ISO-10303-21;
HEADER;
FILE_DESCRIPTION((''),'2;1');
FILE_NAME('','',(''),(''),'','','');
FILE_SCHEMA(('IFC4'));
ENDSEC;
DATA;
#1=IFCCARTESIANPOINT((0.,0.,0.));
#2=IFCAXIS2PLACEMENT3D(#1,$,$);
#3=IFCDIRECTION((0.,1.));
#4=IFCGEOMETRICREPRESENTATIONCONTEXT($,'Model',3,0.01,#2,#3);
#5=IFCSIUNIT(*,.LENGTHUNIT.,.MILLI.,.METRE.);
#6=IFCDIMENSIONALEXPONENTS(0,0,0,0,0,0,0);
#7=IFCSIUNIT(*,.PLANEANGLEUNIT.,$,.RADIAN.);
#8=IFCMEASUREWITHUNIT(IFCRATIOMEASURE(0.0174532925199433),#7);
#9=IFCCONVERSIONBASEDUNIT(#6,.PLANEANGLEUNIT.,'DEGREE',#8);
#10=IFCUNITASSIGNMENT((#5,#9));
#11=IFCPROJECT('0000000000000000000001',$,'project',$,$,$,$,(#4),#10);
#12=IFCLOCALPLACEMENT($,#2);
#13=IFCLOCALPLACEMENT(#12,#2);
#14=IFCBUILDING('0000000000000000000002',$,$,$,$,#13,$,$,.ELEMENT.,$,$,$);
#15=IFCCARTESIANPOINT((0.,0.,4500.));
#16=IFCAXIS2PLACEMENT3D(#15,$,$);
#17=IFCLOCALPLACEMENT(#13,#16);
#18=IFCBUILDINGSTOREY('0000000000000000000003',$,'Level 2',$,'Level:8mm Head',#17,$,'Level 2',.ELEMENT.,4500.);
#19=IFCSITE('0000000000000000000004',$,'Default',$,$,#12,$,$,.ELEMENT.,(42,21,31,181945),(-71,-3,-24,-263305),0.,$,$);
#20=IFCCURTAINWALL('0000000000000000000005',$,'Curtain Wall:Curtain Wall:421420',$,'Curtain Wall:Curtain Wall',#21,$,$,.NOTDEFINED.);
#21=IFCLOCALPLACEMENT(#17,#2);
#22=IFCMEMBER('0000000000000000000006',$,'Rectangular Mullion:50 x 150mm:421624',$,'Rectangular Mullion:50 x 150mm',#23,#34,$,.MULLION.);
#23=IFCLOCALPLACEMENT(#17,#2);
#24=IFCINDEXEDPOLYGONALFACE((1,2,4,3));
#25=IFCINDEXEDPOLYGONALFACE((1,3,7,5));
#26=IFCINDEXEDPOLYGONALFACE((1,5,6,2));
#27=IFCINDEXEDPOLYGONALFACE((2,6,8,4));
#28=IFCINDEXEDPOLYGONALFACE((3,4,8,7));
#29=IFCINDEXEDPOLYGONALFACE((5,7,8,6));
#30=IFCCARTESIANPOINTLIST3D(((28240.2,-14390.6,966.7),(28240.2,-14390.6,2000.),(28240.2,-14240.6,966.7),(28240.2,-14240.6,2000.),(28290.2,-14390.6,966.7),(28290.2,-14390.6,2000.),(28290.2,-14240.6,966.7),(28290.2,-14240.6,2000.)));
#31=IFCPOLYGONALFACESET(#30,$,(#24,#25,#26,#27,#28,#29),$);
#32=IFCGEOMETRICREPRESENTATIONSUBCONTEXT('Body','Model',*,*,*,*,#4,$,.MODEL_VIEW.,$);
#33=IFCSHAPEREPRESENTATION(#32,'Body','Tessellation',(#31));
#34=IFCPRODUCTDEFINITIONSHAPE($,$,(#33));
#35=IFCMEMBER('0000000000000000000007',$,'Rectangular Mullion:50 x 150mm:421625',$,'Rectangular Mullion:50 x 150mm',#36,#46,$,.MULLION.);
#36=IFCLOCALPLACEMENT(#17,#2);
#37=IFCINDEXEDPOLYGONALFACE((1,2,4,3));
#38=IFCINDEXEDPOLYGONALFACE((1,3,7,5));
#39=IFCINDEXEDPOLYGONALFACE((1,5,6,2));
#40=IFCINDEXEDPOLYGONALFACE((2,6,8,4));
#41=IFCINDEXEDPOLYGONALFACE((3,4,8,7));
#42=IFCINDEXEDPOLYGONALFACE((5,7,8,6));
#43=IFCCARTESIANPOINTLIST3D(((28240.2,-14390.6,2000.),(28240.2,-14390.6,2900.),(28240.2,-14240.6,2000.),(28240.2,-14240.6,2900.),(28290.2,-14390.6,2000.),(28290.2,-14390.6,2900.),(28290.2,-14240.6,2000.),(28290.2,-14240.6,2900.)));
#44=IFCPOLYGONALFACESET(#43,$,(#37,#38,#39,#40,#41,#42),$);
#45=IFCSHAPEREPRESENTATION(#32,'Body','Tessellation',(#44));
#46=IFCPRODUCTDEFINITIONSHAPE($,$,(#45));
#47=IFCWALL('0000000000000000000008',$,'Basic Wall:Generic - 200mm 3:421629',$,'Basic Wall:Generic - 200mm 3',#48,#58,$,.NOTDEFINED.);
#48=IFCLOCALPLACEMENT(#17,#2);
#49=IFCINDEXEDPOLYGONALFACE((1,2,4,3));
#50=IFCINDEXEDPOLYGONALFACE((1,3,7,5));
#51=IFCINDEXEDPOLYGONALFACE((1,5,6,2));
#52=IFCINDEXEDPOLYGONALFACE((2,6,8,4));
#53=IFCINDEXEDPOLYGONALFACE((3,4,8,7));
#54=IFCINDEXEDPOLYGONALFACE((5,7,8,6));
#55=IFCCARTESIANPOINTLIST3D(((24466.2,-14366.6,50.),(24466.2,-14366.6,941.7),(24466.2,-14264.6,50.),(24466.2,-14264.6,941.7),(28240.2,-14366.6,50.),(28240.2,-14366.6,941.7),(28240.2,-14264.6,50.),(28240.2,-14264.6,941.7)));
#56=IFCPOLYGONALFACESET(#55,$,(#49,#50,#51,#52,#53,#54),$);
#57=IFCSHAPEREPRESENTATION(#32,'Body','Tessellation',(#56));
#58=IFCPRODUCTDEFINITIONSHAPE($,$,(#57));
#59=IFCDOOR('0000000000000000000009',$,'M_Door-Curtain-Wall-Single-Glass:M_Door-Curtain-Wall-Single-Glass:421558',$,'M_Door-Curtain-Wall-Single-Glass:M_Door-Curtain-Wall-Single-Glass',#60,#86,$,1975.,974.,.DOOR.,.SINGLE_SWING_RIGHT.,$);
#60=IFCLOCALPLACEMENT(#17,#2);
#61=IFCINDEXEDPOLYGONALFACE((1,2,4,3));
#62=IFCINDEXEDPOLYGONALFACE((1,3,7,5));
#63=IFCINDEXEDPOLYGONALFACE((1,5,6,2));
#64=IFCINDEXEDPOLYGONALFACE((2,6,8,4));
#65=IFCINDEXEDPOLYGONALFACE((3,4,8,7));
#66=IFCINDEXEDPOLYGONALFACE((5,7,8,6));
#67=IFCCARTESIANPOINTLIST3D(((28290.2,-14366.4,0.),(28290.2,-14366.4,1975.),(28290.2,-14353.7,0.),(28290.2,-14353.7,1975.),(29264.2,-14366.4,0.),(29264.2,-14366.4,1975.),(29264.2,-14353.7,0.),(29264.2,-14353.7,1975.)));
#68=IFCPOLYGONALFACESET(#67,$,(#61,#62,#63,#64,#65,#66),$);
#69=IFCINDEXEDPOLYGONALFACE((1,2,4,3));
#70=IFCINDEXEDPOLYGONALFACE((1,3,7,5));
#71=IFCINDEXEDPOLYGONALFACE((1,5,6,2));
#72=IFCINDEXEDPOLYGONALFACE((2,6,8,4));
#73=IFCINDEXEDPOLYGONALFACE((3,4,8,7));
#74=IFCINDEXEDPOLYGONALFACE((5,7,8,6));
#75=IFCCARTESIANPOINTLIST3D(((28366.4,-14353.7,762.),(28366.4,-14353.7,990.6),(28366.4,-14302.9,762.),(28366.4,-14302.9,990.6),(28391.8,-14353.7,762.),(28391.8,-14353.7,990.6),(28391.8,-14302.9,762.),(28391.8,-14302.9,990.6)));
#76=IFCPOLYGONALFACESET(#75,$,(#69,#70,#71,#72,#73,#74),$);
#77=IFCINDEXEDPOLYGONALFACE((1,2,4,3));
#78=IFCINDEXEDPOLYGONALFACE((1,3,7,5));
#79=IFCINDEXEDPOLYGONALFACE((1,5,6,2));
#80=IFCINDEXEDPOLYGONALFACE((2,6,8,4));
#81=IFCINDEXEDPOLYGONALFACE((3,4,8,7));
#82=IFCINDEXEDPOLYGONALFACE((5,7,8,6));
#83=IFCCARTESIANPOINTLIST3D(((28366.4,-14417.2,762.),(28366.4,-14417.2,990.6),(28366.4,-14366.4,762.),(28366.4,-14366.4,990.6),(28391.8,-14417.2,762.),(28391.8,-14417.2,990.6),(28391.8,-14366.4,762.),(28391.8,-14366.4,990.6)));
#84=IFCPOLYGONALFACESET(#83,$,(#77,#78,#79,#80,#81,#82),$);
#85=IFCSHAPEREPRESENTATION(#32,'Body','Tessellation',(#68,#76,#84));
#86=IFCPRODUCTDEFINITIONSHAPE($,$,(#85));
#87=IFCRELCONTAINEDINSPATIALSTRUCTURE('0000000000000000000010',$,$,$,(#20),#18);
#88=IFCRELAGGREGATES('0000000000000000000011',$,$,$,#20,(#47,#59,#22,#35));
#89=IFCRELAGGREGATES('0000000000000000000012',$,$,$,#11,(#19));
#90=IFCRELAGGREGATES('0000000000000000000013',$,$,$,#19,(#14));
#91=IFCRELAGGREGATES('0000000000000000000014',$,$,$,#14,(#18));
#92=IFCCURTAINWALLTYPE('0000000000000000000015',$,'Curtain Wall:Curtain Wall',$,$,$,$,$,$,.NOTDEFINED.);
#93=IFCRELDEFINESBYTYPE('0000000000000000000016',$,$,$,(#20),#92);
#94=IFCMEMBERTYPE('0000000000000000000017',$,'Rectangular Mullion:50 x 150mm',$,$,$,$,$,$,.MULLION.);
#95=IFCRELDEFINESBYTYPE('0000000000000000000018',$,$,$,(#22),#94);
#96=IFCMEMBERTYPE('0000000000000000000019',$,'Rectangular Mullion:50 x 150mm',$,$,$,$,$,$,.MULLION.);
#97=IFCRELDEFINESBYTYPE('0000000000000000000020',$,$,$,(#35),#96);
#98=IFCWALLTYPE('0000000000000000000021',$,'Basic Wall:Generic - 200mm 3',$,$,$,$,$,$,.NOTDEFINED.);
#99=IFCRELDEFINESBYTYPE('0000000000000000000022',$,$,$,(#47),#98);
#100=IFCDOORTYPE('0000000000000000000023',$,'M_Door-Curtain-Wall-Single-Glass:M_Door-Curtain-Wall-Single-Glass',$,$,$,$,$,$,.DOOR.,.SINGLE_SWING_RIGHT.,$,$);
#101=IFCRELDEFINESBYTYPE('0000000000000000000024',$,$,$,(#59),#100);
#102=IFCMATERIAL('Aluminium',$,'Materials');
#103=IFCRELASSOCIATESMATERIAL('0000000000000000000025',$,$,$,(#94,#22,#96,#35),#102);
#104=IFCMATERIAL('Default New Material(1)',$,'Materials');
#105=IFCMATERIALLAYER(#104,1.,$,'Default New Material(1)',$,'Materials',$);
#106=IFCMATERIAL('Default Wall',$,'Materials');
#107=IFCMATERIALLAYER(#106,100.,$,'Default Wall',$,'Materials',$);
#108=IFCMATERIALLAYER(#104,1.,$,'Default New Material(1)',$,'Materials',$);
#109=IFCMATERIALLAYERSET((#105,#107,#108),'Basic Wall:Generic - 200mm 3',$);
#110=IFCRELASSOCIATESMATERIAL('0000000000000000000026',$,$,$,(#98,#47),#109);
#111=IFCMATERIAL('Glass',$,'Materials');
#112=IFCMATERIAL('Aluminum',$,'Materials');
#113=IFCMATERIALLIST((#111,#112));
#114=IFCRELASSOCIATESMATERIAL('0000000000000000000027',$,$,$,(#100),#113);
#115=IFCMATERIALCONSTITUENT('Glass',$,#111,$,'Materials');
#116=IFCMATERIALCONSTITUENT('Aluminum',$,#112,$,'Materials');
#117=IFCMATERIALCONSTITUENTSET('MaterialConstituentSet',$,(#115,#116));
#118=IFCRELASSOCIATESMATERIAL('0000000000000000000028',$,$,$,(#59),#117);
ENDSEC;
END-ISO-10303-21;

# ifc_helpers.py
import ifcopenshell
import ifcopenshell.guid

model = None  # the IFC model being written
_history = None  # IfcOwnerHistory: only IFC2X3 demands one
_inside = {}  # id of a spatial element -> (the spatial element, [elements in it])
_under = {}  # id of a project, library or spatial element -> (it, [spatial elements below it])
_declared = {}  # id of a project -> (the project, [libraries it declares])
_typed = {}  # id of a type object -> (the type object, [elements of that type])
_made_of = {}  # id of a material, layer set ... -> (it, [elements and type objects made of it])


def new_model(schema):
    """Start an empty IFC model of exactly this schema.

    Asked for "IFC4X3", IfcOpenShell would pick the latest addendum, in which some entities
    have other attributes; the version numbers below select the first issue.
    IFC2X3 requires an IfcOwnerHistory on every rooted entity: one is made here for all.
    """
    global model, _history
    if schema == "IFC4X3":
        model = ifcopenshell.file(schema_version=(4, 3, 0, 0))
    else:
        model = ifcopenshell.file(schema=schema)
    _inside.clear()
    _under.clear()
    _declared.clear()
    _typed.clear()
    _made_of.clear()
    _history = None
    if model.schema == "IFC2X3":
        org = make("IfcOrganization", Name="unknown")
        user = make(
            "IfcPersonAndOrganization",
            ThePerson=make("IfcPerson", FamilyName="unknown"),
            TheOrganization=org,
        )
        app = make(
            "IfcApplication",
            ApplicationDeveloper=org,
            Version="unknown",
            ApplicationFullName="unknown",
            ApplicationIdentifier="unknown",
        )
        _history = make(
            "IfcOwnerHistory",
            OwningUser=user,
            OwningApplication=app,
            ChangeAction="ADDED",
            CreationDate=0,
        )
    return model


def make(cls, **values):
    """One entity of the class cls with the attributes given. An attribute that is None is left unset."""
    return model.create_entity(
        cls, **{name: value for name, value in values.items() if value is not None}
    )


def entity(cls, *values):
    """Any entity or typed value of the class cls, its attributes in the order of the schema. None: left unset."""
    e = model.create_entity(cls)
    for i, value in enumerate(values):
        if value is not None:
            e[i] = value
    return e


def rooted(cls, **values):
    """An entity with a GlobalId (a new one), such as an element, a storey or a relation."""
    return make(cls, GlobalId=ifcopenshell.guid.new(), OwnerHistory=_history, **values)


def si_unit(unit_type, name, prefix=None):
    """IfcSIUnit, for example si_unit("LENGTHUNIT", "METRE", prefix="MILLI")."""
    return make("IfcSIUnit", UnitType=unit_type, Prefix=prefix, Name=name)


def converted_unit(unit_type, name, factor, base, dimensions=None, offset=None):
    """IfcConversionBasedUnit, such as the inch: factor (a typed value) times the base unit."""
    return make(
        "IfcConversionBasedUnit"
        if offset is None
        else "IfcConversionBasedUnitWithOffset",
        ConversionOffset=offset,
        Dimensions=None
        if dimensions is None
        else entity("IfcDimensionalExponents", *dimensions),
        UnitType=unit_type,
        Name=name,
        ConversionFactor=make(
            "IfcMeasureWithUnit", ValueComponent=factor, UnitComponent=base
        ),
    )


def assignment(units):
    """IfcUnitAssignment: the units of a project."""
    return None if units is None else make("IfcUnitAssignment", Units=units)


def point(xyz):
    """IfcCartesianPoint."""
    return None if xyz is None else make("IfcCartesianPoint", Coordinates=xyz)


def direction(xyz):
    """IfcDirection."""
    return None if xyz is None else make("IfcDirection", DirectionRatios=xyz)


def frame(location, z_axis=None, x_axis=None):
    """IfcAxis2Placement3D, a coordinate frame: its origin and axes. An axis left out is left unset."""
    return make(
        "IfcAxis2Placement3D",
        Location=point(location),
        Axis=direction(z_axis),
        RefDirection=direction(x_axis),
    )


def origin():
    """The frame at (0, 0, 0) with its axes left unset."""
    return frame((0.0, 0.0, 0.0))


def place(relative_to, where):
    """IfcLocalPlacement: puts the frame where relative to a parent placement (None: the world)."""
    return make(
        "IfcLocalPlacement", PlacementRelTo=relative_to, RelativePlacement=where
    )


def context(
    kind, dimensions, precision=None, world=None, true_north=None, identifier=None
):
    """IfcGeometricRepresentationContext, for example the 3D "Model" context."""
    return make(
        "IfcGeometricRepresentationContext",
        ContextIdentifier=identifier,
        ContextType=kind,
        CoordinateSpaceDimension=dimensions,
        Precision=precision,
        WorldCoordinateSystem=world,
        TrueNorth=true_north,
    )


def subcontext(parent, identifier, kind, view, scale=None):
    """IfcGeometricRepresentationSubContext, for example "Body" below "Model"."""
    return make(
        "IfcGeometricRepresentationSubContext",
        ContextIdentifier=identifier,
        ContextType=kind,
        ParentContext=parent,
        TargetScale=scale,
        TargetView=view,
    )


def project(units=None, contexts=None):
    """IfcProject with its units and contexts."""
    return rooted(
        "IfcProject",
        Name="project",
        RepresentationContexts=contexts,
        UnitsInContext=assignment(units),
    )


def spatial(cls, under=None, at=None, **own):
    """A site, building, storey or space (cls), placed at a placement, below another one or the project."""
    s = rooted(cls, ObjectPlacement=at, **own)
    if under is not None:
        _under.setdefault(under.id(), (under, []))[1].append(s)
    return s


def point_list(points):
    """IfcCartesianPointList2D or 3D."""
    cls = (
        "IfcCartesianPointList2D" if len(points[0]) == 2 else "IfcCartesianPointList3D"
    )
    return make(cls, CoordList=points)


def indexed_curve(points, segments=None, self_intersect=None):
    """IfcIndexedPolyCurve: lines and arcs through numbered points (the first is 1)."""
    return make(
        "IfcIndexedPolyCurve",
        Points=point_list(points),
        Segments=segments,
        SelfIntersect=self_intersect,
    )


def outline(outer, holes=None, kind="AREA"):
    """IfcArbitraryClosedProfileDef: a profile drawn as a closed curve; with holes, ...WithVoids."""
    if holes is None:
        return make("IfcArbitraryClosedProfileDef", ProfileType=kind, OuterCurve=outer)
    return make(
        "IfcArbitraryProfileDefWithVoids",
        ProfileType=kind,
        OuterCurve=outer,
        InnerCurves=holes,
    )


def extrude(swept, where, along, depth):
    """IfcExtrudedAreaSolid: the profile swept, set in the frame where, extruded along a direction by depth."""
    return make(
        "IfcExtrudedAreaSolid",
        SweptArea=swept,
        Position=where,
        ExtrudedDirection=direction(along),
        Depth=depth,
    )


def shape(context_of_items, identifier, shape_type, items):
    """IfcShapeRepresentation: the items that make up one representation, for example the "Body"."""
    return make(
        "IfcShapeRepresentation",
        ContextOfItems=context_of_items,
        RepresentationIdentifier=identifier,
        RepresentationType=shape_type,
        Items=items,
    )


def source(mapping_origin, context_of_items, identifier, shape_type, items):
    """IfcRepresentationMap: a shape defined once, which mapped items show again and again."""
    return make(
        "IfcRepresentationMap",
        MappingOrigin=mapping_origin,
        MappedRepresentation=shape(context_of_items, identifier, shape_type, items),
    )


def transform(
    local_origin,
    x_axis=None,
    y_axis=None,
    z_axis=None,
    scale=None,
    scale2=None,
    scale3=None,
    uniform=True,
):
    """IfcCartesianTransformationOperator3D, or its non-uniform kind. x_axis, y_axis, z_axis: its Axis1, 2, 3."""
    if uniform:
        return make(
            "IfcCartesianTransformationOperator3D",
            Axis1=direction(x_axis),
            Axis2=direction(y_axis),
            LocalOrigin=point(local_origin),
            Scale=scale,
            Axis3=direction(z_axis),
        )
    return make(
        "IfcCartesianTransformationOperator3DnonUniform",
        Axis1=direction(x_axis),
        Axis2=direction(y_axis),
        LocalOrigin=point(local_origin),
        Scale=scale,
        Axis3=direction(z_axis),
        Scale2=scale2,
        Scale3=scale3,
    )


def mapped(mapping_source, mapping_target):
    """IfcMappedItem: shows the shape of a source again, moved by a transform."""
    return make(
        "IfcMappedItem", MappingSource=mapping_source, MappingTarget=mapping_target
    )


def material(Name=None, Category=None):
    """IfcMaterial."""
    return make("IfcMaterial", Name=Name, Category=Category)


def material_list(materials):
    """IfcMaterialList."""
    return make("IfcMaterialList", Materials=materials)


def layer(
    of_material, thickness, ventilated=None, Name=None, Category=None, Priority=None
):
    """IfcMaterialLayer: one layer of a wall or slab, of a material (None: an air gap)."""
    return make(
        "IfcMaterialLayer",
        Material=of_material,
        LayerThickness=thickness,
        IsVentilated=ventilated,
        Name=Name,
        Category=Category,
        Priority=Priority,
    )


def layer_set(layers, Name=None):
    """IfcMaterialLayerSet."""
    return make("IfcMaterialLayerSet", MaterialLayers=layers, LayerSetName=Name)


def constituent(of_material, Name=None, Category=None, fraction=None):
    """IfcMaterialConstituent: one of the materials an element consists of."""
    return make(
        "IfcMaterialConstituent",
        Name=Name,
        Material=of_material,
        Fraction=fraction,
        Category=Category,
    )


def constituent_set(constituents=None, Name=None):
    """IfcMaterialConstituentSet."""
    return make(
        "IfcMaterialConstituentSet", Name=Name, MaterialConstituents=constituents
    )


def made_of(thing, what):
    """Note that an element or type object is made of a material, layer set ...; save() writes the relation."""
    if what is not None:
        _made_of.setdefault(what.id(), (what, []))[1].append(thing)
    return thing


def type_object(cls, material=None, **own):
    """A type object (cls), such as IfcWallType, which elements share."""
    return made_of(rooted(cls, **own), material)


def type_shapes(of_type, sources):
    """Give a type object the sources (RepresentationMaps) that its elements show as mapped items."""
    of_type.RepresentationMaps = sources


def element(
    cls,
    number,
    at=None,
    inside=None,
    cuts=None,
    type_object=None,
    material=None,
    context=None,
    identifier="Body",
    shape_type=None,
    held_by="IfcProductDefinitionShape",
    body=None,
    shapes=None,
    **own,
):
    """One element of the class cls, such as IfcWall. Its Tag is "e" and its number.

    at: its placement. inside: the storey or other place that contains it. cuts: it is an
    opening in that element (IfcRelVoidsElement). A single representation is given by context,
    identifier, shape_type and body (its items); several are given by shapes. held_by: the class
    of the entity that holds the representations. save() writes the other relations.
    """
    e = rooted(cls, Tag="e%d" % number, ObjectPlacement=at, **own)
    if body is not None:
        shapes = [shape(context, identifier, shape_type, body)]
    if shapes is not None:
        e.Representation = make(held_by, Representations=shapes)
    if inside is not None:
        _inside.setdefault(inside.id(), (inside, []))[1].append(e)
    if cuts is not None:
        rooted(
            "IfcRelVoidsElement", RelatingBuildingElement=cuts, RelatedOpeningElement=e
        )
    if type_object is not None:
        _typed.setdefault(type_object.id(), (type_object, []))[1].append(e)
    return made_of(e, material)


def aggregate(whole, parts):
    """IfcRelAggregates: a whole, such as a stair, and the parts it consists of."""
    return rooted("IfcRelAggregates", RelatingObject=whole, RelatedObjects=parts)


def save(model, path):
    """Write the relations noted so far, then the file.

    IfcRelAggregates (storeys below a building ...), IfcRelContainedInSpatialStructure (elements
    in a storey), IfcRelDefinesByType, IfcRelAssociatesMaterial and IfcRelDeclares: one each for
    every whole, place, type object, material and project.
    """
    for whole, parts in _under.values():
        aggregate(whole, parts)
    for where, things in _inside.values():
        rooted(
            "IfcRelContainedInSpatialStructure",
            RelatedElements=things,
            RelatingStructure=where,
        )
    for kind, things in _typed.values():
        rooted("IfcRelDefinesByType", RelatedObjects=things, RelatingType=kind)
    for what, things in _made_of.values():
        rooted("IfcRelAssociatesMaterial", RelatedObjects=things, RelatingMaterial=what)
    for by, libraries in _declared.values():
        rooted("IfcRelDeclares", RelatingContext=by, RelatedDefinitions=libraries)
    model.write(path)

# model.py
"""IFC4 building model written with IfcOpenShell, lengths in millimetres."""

from ifc_helpers import new_model, entity, si_unit, converted_unit, direction, frame, origin, place, context, subcontext, project, spatial, indexed_curve, outline, extrude, source, transform, mapped, material, material_list, layer, layer_set, constituent, constituent_set, type_object, type_shapes, element, aggregate, save


model = new_model("IFC4")

# Units and contexts
model_context = context("Model", 3, precision=0.01, world=origin(), true_north=direction((0.0, 1.0)))
body_context = subcontext(model_context, "Body", "Model", "MODEL_VIEW")
ifc_project = project(units=[si_unit("LENGTHUNIT", "METRE", prefix="MILLI"), converted_unit("PLANEANGLEUNIT", "DEGREE", entity("IfcRatioMeasure", 0.0174532925199433), si_unit("PLANEANGLEUNIT", "RADIAN"), dimensions=[0, 0, 0, 0, 0, 0, 0])], contexts=[model_context])

# Site, building, storey
site_placement = place(None, origin())
site = spatial("IfcSite", under=ifc_project, at=site_placement, Name="Default", CompositionType="ELEMENT", RefLatitude=(42, 21, 31, 181945), RefLongitude=(-71, -3, -24, -263305), RefElevation=0.0)
building_placement = place(site_placement, origin())
building = spatial("IfcBuilding", under=site, at=building_placement, CompositionType="ELEMENT")
storey_placement = place(building_placement, frame((0.0, 0.0, 4500.0)))
storey = spatial("IfcBuildingStorey", under=building, at=storey_placement, Name="Level 2", ObjectType="Level:8mm Head", LongName="Level 2", CompositionType="ELEMENT", Elevation=4500.0)

# Curtain wall, members
ifc_material_1 = material(Name="Aluminium", Category="Materials")
curtain_wall_type_1 = type_object("IfcCurtainWallType", Name="Curtain Wall:Curtain Wall", PredefinedType="NOTDEFINED")
curtain_wall_1_placement = place(storey_placement, frame((0.0, 0.0, -4500.0)))
curtain_wall_1 = element("IfcCurtainWall", 1, at=curtain_wall_1_placement, inside=storey, type_object=curtain_wall_type_1, Name="Curtain Wall:Curtain Wall:421420", ObjectType="Curtain Wall:Curtain Wall", PredefinedType="NOTDEFINED")
member_type_1 = type_object("IfcMemberType", Name="Rectangular Mullion:50 x 150mm", PredefinedType="MULLION", material=ifc_material_1)
shared_shape_1 = source(origin(), body_context, "Body", "SweptSolid", [
    extrude(outline(indexed_curve([(-75.0, -25.0), (75.0, -25.0), (75.0, 25.0), (-75.0, 25.0), (-75.0, -25.0)], self_intersect=False)), frame((0.0, 0.0, -1033.3), z_axis=(0.0, 0.0, 1.0), x_axis=(0.0, -1.0, 0.0)), (0.0, 0.0, 1.0), 1033.3),
])
type_shapes(member_type_1, [shared_shape_1])
member_1_placement = place(storey_placement, frame((28265.2, -14315.6, 966.7), z_axis=(0.0, 0.0, -1.0), x_axis=(1.0, 0.0, 0.0)))
member_1 = element("IfcMember", 2, at=member_1_placement, type_object=member_type_1, material=ifc_material_1, Name="Rectangular Mullion:50 x 150mm:421624", ObjectType="Rectangular Mullion:50 x 150mm", PredefinedType="MULLION", context=body_context, shape_type="MappedRepresentation", body=[
    mapped(shared_shape_1, transform((0.0, 0.0, 0.0), scale=1.0)),
])
member_type_2 = type_object("IfcMemberType", Name="Rectangular Mullion:50 x 150mm", PredefinedType="MULLION", material=ifc_material_1)
shared_shape_2 = source(origin(), body_context, "Body", "SweptSolid", [
    extrude(outline(indexed_curve([(-75.0, -25.0), (75.0, -25.0), (75.0, 25.0), (-75.0, 25.0), (-75.0, -25.0)], self_intersect=False)), frame((0.0, 0.0, -900.0), z_axis=(0.0, 0.0, 1.0), x_axis=(0.0, -1.0, 0.0)), (0.0, 0.0, 1.0), 900.0),
])
type_shapes(member_type_2, [shared_shape_2])
member_2_placement = place(storey_placement, frame((28265.2, -14315.6, 2000.0), z_axis=(0.0, 0.0, -1.0), x_axis=(1.0, 0.0, 0.0)))
member_2 = element("IfcMember", 3, at=member_2_placement, type_object=member_type_2, material=ifc_material_1, Name="Rectangular Mullion:50 x 150mm:421625", ObjectType="Rectangular Mullion:50 x 150mm", PredefinedType="MULLION", context=body_context, shape_type="MappedRepresentation", body=[
    mapped(shared_shape_2, transform((0.0, 0.0, 0.0), scale=1.0)),
])

# Shared definitions
ifc_material_2 = material(Name="Glass", Category="Materials")

# Wall
ifc_material_3 = material(Name="Default New Material(1)", Category="Materials")
ifc_layer_1 = layer(ifc_material_3, 1.0, Name="Default New Material(1)", Category="Materials")
ifc_material_4 = material(Name="Default Wall", Category="Materials")
ifc_layer_2 = layer(ifc_material_4, 100.0, Name="Default Wall", Category="Materials")
ifc_layer_3 = layer(ifc_material_3, 1.0, Name="Default New Material(1)", Category="Materials")
ifc_layer_set = layer_set([ifc_layer_1, ifc_layer_2, ifc_layer_3], Name="Basic Wall:Generic - 200mm 3")
wall_type = type_object("IfcWallType", Name="Basic Wall:Generic - 200mm 3", PredefinedType="NOTDEFINED", material=ifc_layer_set)
wall_placement = place(storey_placement, frame((24466.2, -14315.6, 50.0)))
wall = element("IfcWall", 4, at=wall_placement, type_object=wall_type, material=ifc_layer_set, Name="Basic Wall:Generic - 200mm 3:421629", ObjectType="Basic Wall:Generic - 200mm 3", PredefinedType="NOTDEFINED", context=body_context, shape_type="SweptSolid", body=[
    extrude(outline(indexed_curve([(3774.0, 51.0), (0.0, 51.0), (0.0, -51.0), (3774.0, -51.0), (3774.0, 51.0)], self_intersect=False)), origin(), (0.0, 0.0, 1.0), 891.7),
])

# Door
ifc_constituent_1 = constituent(ifc_material_2, Name="Glass", Category="Materials")
ifc_material_5 = material(Name="Aluminum", Category="Materials")
ifc_constituent_2 = constituent(ifc_material_5, Name="Aluminum", Category="Materials")
ifc_constituent_set_1 = constituent_set(constituents=[ifc_constituent_1, ifc_constituent_2], Name="MaterialConstituentSet")
ifc_material_list_1 = material_list([ifc_material_2, ifc_material_5])
door_type = type_object("IfcDoorType", Name="M_Door-Curtain-Wall-Single-Glass:M_Door-Curtain-Wall-Single-Glass", OperationType="SINGLE_SWING_RIGHT", PredefinedType="DOOR", material=ifc_material_list_1)
shared_shape_3 = source(origin(), body_context, "Body", "SweptSolid", [
    extrude(outline(indexed_curve([(-6.4, -487.0), (6.4, -487.0), (6.4, 487.0), (-6.4, 487.0), (-6.4, -487.0)], self_intersect=False)), frame((0.0, -44.5, 0.0), z_axis=(0.0, 0.0, 1.0), x_axis=(0.0, 1.0, 0.0)), (0.0, 0.0, 1.0), 1975.0),
    extrude(outline(indexed_curve([(-12.7, -25.4), (12.7, -25.4), (12.7, 25.4), (-12.7, 25.4), (-12.7, -25.4)], self_intersect=False)), frame((-398.1, -12.7, 762.0), z_axis=(0.0, 0.0, 1.0), x_axis=(-1.0, 0.0, 0.0)), (0.0, 0.0, 1.0), 228.6),
    extrude(outline(indexed_curve([(-12.7, -25.4), (12.7, -25.4), (12.7, 25.4), (-12.7, 25.4), (-12.7, -25.4)], self_intersect=False)), frame((-398.1, -76.2, 762.0)), (0.0, 0.0, 1.0), 228.6),
])
type_shapes(door_type, [shared_shape_3])
door_placement = place(curtain_wall_1_placement, frame((28777.2, -14315.6, 4500.0)))
door = element("IfcDoor", 5, at=door_placement, type_object=door_type, material=ifc_constituent_set_1, Name="M_Door-Curtain-Wall-Single-Glass:M_Door-Curtain-Wall-Single-Glass:421558", ObjectType="M_Door-Curtain-Wall-Single-Glass:M_Door-Curtain-Wall-Single-Glass", OperationType="SINGLE_SWING_RIGHT", OverallHeight=1975.0, OverallWidth=974.0, PredefinedType="DOOR", context=body_context, shape_type="MappedRepresentation", body=[
    mapped(shared_shape_3, transform((0.0, 0.0, 0.0), scale=1.0)),
])
aggregate(curtain_wall_1, [wall, door, member_1, member_2])

save(model, "model.ifc")
